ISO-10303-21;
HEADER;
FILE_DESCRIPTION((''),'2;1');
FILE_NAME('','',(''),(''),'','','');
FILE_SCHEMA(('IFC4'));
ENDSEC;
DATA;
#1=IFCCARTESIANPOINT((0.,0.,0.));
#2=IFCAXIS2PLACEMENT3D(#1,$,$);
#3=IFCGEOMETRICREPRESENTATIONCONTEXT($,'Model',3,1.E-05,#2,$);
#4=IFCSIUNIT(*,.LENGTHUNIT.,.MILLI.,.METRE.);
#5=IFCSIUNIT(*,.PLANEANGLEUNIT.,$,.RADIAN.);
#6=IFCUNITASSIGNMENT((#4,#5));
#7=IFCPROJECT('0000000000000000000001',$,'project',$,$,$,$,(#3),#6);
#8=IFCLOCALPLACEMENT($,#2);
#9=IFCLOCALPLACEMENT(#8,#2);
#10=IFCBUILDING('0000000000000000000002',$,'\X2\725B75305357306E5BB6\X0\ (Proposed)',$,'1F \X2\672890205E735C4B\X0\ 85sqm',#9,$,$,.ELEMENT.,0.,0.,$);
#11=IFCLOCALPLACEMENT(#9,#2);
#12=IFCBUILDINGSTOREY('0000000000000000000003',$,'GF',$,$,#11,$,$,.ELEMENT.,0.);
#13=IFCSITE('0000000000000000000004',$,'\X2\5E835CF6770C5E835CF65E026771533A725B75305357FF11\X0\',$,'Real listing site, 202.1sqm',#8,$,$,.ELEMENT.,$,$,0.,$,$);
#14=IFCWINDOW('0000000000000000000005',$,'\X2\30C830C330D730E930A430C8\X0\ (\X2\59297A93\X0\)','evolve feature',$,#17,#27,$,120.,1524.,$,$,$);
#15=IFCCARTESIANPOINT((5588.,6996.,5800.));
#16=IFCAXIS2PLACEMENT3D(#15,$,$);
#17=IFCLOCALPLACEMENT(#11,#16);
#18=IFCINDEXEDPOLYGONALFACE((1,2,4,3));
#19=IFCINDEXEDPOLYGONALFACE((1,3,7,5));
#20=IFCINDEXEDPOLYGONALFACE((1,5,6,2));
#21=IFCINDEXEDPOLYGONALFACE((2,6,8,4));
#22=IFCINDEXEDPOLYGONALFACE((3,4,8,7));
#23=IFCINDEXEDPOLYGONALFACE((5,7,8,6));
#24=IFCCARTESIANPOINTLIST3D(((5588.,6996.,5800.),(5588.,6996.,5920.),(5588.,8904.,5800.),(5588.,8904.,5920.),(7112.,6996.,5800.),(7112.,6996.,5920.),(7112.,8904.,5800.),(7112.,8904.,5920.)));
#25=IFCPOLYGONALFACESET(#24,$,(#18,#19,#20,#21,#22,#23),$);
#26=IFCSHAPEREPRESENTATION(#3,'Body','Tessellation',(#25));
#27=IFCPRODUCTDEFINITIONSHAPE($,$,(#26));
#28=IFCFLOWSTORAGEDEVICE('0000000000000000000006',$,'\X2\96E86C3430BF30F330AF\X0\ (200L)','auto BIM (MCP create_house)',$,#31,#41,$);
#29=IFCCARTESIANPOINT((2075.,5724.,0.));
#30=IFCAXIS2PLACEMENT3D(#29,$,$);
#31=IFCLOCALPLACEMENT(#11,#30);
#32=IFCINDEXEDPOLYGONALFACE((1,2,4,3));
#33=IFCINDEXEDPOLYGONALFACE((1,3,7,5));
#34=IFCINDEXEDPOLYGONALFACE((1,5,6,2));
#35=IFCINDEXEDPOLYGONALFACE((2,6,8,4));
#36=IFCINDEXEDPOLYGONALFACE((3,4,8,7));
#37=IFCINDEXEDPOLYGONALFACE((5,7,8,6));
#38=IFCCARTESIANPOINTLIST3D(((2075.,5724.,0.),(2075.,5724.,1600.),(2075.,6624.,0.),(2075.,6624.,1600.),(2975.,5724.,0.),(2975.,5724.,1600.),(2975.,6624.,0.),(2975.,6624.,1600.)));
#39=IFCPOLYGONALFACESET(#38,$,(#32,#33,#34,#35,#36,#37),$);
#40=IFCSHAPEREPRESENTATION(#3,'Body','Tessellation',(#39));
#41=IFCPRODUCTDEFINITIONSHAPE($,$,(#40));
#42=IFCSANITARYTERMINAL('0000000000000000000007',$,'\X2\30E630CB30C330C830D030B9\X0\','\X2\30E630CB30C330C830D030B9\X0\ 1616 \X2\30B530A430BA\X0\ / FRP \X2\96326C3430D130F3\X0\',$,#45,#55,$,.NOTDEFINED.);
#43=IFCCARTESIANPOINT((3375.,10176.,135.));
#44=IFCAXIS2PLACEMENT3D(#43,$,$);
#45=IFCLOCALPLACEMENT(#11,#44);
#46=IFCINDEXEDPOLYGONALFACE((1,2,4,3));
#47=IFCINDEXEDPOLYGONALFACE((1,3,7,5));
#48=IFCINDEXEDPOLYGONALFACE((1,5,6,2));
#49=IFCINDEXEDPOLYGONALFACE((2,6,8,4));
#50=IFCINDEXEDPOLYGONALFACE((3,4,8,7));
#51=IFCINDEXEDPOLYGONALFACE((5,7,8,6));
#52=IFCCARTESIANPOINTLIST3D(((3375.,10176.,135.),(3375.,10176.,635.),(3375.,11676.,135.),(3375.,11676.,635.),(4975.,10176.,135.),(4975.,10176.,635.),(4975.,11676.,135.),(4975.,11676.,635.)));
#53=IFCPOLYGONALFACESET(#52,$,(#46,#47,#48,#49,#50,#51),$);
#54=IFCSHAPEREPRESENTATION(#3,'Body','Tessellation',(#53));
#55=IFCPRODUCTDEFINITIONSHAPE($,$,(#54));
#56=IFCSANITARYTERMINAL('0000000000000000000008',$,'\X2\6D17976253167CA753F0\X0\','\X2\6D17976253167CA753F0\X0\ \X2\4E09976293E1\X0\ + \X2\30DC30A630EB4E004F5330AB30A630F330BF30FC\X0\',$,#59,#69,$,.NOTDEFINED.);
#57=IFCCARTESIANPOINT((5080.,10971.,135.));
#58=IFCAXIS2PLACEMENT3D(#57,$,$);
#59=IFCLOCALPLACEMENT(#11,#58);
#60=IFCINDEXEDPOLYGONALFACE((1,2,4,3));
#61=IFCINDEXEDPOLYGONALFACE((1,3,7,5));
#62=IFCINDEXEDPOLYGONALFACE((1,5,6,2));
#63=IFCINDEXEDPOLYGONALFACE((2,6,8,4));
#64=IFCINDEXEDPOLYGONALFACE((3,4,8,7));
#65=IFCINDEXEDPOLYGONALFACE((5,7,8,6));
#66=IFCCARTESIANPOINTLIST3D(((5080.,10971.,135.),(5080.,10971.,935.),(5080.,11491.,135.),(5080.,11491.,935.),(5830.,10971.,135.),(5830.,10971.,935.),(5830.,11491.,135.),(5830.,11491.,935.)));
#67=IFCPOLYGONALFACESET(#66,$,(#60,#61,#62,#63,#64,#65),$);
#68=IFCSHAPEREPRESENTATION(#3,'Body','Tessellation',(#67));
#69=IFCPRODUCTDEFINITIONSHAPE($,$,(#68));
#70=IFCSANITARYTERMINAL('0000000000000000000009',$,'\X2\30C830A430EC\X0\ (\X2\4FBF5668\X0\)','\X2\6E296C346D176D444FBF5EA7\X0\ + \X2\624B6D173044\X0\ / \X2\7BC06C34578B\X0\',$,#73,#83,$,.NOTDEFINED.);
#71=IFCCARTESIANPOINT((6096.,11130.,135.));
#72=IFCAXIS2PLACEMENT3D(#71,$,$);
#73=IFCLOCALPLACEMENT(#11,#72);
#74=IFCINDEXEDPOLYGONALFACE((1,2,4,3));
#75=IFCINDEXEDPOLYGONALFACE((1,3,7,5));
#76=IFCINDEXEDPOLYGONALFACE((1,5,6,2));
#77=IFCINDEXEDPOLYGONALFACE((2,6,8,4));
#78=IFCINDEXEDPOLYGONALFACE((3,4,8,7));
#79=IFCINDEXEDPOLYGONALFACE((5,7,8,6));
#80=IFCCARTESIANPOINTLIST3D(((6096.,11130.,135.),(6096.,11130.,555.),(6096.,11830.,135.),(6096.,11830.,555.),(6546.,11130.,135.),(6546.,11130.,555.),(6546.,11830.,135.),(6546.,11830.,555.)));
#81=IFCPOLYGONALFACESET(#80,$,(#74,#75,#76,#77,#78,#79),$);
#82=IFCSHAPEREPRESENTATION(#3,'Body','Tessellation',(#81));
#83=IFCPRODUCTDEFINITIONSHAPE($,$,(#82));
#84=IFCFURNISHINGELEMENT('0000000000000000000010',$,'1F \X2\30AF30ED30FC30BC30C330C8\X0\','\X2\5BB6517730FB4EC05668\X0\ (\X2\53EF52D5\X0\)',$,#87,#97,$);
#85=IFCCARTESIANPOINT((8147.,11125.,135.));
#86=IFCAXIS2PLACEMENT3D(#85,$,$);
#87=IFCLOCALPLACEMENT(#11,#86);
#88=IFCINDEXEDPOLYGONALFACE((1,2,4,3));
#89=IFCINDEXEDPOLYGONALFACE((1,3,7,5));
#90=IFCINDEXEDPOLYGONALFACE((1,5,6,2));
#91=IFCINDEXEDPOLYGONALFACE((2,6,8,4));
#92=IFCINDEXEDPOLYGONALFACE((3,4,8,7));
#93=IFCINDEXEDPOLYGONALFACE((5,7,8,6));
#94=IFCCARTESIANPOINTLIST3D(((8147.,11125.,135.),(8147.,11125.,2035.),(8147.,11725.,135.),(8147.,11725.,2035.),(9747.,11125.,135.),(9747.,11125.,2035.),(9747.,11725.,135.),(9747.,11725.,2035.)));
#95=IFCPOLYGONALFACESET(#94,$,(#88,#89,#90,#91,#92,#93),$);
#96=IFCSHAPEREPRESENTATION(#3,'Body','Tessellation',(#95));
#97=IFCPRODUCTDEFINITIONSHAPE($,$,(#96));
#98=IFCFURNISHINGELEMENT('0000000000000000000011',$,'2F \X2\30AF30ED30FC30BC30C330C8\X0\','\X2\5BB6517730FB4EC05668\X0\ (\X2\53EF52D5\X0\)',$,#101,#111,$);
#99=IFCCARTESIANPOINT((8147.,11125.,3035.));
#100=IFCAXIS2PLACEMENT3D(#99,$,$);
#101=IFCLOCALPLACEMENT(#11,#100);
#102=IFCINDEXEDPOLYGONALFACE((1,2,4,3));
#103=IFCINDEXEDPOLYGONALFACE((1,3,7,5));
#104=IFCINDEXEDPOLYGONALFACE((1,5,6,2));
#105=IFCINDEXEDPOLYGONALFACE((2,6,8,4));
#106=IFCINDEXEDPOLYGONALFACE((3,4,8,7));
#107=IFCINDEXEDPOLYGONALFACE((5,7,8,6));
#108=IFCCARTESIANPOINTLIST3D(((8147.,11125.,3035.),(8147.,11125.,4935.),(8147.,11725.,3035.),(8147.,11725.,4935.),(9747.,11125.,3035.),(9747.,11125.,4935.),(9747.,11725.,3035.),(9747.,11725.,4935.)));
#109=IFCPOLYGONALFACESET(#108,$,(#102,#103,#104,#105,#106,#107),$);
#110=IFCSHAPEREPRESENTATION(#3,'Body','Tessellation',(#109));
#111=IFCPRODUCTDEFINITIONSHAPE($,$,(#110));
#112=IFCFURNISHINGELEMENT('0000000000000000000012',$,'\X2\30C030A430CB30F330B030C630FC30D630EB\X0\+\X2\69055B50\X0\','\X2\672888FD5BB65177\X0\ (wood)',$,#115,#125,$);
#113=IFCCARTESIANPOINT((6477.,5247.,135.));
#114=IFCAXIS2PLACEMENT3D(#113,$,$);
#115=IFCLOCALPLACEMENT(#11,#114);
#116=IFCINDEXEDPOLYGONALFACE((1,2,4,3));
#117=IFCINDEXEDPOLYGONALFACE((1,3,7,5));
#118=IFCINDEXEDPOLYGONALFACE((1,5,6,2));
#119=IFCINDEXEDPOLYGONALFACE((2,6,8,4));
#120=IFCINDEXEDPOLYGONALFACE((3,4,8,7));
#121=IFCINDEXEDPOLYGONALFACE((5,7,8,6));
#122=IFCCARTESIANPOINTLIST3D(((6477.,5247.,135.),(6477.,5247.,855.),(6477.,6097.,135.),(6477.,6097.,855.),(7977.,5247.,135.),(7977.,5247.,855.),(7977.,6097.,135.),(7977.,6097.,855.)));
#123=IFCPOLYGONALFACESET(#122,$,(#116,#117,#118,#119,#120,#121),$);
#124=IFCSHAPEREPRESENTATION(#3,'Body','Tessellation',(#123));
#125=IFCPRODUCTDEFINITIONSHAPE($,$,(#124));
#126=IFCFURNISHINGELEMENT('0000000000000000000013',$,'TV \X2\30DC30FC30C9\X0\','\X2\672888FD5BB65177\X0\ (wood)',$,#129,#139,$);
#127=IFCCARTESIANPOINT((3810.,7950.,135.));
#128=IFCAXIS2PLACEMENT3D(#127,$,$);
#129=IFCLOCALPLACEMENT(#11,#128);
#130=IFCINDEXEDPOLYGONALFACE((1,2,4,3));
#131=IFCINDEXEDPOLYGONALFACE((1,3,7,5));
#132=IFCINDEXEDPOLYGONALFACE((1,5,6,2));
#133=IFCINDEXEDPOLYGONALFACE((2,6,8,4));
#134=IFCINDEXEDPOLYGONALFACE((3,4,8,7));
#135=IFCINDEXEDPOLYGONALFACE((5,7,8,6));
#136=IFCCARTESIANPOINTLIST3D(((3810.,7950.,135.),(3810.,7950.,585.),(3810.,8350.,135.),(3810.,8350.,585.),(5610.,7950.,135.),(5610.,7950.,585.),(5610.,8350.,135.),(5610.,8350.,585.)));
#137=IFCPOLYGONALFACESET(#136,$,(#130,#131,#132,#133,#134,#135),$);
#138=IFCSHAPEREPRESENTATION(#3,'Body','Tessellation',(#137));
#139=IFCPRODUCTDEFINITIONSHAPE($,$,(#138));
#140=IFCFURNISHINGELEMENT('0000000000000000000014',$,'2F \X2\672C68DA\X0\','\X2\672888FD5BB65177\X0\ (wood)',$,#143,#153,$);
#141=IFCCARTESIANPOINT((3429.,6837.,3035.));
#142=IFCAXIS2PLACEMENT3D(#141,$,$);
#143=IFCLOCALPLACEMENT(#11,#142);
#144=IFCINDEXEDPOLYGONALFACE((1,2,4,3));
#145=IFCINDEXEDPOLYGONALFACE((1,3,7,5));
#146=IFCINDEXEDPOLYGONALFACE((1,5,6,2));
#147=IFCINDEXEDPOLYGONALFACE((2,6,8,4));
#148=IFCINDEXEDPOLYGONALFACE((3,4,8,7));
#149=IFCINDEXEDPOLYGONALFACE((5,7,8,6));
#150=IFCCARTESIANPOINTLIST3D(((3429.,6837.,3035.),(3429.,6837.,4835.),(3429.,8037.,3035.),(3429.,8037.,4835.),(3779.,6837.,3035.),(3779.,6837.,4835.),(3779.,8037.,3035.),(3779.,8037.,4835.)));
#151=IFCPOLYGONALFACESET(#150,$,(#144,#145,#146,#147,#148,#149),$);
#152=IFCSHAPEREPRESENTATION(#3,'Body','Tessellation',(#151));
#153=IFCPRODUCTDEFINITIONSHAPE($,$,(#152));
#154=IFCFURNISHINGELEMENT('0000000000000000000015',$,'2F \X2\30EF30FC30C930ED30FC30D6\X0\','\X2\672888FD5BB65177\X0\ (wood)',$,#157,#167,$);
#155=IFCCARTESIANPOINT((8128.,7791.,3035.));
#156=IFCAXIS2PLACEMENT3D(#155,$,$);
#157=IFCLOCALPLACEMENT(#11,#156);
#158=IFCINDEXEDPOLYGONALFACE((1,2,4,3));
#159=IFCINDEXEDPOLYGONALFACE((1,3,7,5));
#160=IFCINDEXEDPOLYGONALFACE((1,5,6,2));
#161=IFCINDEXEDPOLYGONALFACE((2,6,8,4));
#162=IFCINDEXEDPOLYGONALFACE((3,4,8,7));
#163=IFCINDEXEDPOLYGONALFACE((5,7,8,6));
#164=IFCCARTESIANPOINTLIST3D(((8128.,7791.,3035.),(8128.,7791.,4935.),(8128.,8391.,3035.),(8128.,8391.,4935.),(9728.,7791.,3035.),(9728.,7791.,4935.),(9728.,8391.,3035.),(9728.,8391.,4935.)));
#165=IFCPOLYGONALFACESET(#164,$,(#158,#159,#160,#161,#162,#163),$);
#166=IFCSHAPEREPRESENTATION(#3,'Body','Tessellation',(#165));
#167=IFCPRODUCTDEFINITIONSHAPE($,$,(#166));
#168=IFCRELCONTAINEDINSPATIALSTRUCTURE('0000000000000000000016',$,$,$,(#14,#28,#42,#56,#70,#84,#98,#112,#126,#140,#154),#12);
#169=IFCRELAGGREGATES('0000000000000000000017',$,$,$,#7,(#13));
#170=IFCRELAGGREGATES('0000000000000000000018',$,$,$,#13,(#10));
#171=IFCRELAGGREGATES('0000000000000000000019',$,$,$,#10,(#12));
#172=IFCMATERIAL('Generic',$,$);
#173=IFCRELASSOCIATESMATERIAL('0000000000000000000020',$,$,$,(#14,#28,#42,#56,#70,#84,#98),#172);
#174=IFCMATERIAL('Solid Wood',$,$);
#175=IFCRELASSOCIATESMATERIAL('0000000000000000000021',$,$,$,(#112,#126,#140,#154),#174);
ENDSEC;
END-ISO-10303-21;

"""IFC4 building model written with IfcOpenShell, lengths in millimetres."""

from ifc_helpers import new_model, si_unit, frame, frame_2d, origin, place, context, project, spatial, rectangle, extrude, material, element, save


model = new_model("IFC4")

# Units and contexts
model_context = context("Model", 3, precision=1e-05, world=origin())
ifc_project = project(units=[si_unit("LENGTHUNIT", "METRE", prefix="MILLI"), si_unit("PLANEANGLEUNIT", "RADIAN")], contexts=[model_context])

# Site, building, storey
site_placement = place(None, origin())
site = spatial("IfcSite", under=ifc_project, at=site_placement, Name="広島県広島市東区牛田南１", ObjectType="Real listing site, 202.1sqm", CompositionType="ELEMENT", RefElevation=0.0)
building_placement = place(site_placement, origin())
building = spatial("IfcBuilding", under=site, at=building_placement, Name="牛田南の家 (Proposed)", ObjectType="1F 木造平屋 85sqm", CompositionType="ELEMENT", ElevationOfRefHeight=0.0, ElevationOfTerrain=0.0)
storey_placement = place(building_placement, origin())
storey = spatial("IfcBuildingStorey", under=building, at=storey_placement, Name="GF", CompositionType="ELEMENT", Elevation=0.0)

# Shared definitions
ifc_material_1 = material(Name="Solid Wood")

# Window
ifc_material_2 = material(Name="Generic")
window_1_placement = place(storey_placement, frame((5588.0, 6996.0, 5800.0)))
element("IfcWindow", 1, at=window_1_placement, inside=storey, material=ifc_material_2, Name="トップライト (天窓)", Description="evolve feature", OverallHeight=120.0, OverallWidth=1524.0, context=model_context, shape_type="SweptSolid", body=[
    extrude(rectangle(XDim=1524.0, YDim=1908.0, at=frame_2d((762.0, 954.0))), frame((5588.0, 6996.0, 5800.0)), (0.0, 0.0, 1.0), 120.0),
])

# Flow storage device
flow_storage_device_placement = place(storey_placement, frame((2075.0, 5724.0, 0.0)))
element("IfcFlowStorageDevice", 2, at=flow_storage_device_placement, inside=storey, material=ifc_material_2, Name="雨水タンク (200L)", Description="auto BIM (MCP create_house)", context=model_context, shape_type="SweptSolid", body=[
    extrude(rectangle(XDim=900.0, YDim=900.0, at=frame_2d((450.0, 450.0))), frame((2075.0, 5724.0, 0.0)), (0.0, 0.0, 1.0), 1600.0),
])

# Sanitary terminals
sanitary_terminal_1_placement = place(storey_placement, frame((3375.0, 10176.0, 135.0)))
element("IfcSanitaryTerminal", 3, at=sanitary_terminal_1_placement, inside=storey, material=ifc_material_2, Name="ユニットバス", Description="ユニットバス 1616 サイズ / FRP 防水パン", PredefinedType="NOTDEFINED", context=model_context, shape_type="SweptSolid", body=[
    extrude(rectangle(XDim=1600.0, YDim=1500.0, at=frame_2d((800.0, 750.0))), frame((3375.0, 10176.0, 135.0)), (0.0, 0.0, 1.0), 500.0),
])
sanitary_terminal_2_placement = place(storey_placement, frame((5080.0, 10971.0, 135.0)))
element("IfcSanitaryTerminal", 4, at=sanitary_terminal_2_placement, inside=storey, material=ifc_material_2, Name="洗面化粧台", Description="洗面化粧台 三面鏡 + ボウル一体カウンター", PredefinedType="NOTDEFINED", context=model_context, shape_type="SweptSolid", body=[
    extrude(rectangle(XDim=750.0, YDim=520.0, at=frame_2d((375.0, 260.0))), frame((5080.0, 10971.0, 135.0)), (0.0, 0.0, 1.0), 800.0),
])
sanitary_terminal_3_placement = place(storey_placement, frame((6096.0, 11130.0, 135.0)))
element("IfcSanitaryTerminal", 5, at=sanitary_terminal_3_placement, inside=storey, material=ifc_material_2, Name="トイレ (便器)", Description="温水洗浄便座 + 手洗い / 節水型", PredefinedType="NOTDEFINED", context=model_context, shape_type="SweptSolid", body=[
    extrude(rectangle(XDim=450.0, YDim=700.0, at=frame_2d((225.0, 350.0))), frame((6096.0, 11130.0, 135.0)), (0.0, 0.0, 1.0), 420.0),
])

# Furnishing elements
furnishing_1_placement = place(storey_placement, frame((8147.0, 11125.0, 135.0)))
element("IfcFurnishingElement", 6, at=furnishing_1_placement, inside=storey, material=ifc_material_2, Name="1F クローゼット", Description="家具・什器 (可動)", context=model_context, shape_type="SweptSolid", body=[
    extrude(rectangle(XDim=1600.0, YDim=600.0, at=frame_2d((800.0, 300.0))), frame((8147.0, 11125.0, 135.0)), (0.0, 0.0, 1.0), 1900.0),
])
furnishing_2_placement = place(storey_placement, frame((8147.0, 11125.0, 3035.0)))
element("IfcFurnishingElement", 7, at=furnishing_2_placement, inside=storey, material=ifc_material_2, Name="2F クローゼット", Description="家具・什器 (可動)", context=model_context, shape_type="SweptSolid", body=[
    extrude(rectangle(XDim=1600.0, YDim=600.0, at=frame_2d((800.0, 300.0))), frame((8147.0, 11125.0, 3035.0)), (0.0, 0.0, 1.0), 1900.0),
])
furnishing_3_placement = place(storey_placement, frame((6477.0, 5247.0, 135.0)))
element("IfcFurnishingElement", 8, at=furnishing_3_placement, inside=storey, material=ifc_material_1, Name="ダイニングテーブル+椅子", Description="木製家具 (wood)", context=model_context, shape_type="SweptSolid", body=[
    extrude(rectangle(XDim=1500.0, YDim=850.0, at=frame_2d((750.0, 425.0))), frame((6477.0, 5247.0, 135.0)), (0.0, 0.0, 1.0), 720.0),
])
furnishing_4_placement = place(storey_placement, frame((3810.0, 7950.0, 135.0)))
element("IfcFurnishingElement", 9, at=furnishing_4_placement, inside=storey, material=ifc_material_1, Name="TV ボード", Description="木製家具 (wood)", context=model_context, shape_type="SweptSolid", body=[
    extrude(rectangle(XDim=1800.0, YDim=400.0, at=frame_2d((900.0, 200.0))), frame((3810.0, 7950.0, 135.0)), (0.0, 0.0, 1.0), 450.0),
])
furnishing_5_placement = place(storey_placement, frame((3429.0, 6837.0, 3035.0)))
element("IfcFurnishingElement", 10, at=furnishing_5_placement, inside=storey, material=ifc_material_1, Name="2F 本棚", Description="木製家具 (wood)", context=model_context, shape_type="SweptSolid", body=[
    extrude(rectangle(XDim=350.0, YDim=1200.0, at=frame_2d((175.0, 600.0))), frame((3429.0, 6837.0, 3035.0)), (0.0, 0.0, 1.0), 1800.0),
])
furnishing_6_placement = place(storey_placement, frame((8128.0, 7791.0, 3035.0)))
element("IfcFurnishingElement", 11, at=furnishing_6_placement, inside=storey, material=ifc_material_1, Name="2F ワードローブ", Description="木製家具 (wood)", context=model_context, shape_type="SweptSolid", body=[
    extrude(rectangle(XDim=1600.0, YDim=600.0, at=frame_2d((800.0, 300.0))), frame((8128.0, 7791.0, 3035.0)), (0.0, 0.0, 1.0), 1900.0),
])

save(model, "model.ifc")
